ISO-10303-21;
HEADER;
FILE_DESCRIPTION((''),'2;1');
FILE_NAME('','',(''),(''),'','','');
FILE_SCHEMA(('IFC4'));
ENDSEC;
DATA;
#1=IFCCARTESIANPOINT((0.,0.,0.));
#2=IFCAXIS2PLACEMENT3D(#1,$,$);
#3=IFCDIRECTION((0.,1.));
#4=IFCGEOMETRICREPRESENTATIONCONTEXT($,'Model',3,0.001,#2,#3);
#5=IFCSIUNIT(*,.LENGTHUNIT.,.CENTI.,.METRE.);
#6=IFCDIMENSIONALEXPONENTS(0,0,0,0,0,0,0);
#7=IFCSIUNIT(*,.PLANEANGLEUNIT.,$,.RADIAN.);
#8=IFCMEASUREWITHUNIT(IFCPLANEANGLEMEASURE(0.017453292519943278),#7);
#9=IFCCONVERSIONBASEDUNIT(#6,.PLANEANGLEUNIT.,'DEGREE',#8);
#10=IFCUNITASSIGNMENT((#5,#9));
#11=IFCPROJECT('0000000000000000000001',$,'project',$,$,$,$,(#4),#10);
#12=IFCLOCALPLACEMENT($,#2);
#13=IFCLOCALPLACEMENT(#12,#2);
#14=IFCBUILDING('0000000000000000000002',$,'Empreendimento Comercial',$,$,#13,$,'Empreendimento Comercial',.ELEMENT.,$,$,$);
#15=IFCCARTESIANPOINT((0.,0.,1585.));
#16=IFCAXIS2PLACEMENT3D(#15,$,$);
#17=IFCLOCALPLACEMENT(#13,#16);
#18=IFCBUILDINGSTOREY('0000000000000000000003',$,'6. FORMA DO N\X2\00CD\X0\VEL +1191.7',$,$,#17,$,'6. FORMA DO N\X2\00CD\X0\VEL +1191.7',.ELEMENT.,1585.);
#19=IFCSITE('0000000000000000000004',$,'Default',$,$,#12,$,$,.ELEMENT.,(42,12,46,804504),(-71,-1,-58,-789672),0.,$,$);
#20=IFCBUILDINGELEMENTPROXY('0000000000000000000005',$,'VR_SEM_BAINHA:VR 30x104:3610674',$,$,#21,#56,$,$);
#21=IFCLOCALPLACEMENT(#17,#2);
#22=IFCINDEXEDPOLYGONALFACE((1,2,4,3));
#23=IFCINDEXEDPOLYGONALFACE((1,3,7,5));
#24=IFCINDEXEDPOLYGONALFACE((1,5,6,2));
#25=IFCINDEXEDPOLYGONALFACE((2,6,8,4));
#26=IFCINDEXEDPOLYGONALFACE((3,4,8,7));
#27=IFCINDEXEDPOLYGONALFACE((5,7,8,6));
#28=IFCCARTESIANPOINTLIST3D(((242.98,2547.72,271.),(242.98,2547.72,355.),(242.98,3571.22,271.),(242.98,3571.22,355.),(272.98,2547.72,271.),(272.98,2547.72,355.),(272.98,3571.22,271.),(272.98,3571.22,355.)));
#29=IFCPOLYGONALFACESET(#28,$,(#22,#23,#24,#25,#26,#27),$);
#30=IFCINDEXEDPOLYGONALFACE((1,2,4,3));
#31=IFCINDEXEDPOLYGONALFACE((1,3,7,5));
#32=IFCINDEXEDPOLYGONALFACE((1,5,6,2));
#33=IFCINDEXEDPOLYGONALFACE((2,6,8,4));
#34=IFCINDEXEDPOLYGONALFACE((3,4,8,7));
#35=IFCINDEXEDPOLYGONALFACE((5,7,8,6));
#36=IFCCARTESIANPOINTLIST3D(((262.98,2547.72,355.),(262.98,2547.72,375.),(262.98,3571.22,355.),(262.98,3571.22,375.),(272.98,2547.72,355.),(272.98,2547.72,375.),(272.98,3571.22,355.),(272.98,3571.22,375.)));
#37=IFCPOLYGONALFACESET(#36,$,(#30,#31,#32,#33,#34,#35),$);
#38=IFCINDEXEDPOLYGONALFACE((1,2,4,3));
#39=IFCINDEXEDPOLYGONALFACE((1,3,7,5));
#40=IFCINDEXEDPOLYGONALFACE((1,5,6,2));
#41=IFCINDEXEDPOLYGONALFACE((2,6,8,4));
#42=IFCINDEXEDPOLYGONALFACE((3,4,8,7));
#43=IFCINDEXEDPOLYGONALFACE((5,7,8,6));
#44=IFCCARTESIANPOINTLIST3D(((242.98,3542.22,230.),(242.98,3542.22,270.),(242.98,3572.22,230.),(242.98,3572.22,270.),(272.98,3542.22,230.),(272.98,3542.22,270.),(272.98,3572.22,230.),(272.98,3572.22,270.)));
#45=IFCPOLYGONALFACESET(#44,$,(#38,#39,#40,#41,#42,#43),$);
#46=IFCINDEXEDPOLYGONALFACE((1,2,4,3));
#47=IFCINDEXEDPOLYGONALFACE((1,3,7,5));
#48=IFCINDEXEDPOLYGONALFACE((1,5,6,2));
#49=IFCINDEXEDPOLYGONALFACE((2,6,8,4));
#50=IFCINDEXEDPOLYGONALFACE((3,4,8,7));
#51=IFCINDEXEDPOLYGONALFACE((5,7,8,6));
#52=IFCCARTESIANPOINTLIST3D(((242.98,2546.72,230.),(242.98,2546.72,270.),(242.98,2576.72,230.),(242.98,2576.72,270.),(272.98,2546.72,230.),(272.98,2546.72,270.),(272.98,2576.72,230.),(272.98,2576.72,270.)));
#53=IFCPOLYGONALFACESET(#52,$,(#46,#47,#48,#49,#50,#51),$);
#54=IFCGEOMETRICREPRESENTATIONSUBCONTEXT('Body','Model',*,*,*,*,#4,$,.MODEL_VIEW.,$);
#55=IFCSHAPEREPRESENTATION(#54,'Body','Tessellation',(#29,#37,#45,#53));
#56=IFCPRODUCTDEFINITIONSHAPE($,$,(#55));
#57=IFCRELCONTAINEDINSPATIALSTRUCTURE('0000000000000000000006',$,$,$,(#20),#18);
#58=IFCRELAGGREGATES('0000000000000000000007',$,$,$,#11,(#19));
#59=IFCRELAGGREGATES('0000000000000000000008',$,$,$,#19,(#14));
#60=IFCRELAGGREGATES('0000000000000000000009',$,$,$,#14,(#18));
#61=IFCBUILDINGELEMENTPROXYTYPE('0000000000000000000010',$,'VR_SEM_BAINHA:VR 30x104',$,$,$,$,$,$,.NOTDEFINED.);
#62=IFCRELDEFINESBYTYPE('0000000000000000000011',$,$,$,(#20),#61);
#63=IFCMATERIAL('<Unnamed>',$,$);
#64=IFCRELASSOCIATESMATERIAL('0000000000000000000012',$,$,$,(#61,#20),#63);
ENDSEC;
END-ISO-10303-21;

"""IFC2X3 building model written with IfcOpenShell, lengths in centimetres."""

from ifc_helpers import new_model, entity, si_unit, converted_unit, direction, frame, frame_2d, origin, place, context, subcontext, project, spatial, rectangle, extrude, source, transform, mapped, material, type_object, type_shapes, element, save


model = new_model("IFC2X3")

# Units and contexts
model_context = context("Model", 3, precision=0.001, world=origin(), true_north=direction((0.0, 1.0)))
body_context = subcontext(model_context, "Body", "Model", "MODEL_VIEW")
ifc_project = project(units=[si_unit("LENGTHUNIT", "METRE", prefix="CENTI"), converted_unit("PLANEANGLEUNIT", "DEGREE", entity("IfcPlaneAngleMeasure", 0.017453292519943278), si_unit("PLANEANGLEUNIT", "RADIAN"), dimensions=[0, 0, 0, 0, 0, 0, 0])], contexts=[model_context])

# Site, building, storey
site_placement = place(None, origin())
site = spatial("IfcSite", under=ifc_project, at=site_placement, Name="Default", CompositionType="ELEMENT", RefLatitude=(42, 12, 46, 804504), RefLongitude=(-71, -1, -58, -789672), RefElevation=0.0)
building_placement = place(site_placement, origin())
building = spatial("IfcBuilding", under=site, at=building_placement, Name="Empreendimento Comercial", LongName="Empreendimento Comercial", CompositionType="ELEMENT")
storey_placement = place(building_placement, frame((0.0, 0.0, 1585.0)))
storey = spatial("IfcBuildingStorey", under=building, at=storey_placement, Name="6. FORMA DO NÍVEL +1191.7", LongName="6. FORMA DO NÍVEL +1191.7", CompositionType="ELEMENT", Elevation=1585.0)

# Shared definitions
ifc_material = material(Name="<Unnamed>")

# Building element proxy
building_element_proxy_type_1 = type_object("IfcBuildingElementProxyType", Name="VR_SEM_BAINHA:VR 30x104", PredefinedType="NOTDEFINED", material=ifc_material)
shared_shape_1 = source(origin(), body_context, "Body", "SweptSolid", [
    extrude(rectangle(XDim=1023.5, YDim=30.0, at=frame_2d((0.0, 0.0), x_axis=(1.0, 0.0))), frame((257.98, 3059.47, 1856.0), z_axis=(0.0, 0.0, 1.0), x_axis=(0.0, 1.0, 0.0)), (0.0, 0.0, 1.0), 84.0),
    extrude(rectangle(XDim=1023.5, YDim=10.0, at=frame_2d((0.0, 0.0), x_axis=(1.0, 0.0))), frame((267.98, 3059.47, 1940.0), z_axis=(0.0, 0.0, 1.0), x_axis=(0.0, 1.0, 0.0)), (0.0, 0.0, 1.0), 20.0),
    extrude(rectangle(XDim=30.0, YDim=30.0, at=frame_2d((0.0, 0.0), x_axis=(1.0, 0.0))), frame((257.98, 3557.22, 1815.0)), (0.0, 0.0, 1.0), 40.0),
    extrude(rectangle(XDim=30.0, YDim=30.0, at=frame_2d((0.0, 0.0), x_axis=(1.0, 0.0))), frame((257.98, 2561.72, 1815.0)), (0.0, 0.0, 1.0), 40.0),
])
type_shapes(building_element_proxy_type_1, [shared_shape_1])
proxy_1_placement = place(storey_placement, frame((0.0, 0.0, -1585.0)))
element("IfcBuildingElementProxy", 1, at=proxy_1_placement, inside=storey, type_object=building_element_proxy_type_1, material=ifc_material, Name="VR_SEM_BAINHA:VR 30x104:3610674", context=body_context, shape_type="MappedRepresentation", body=[
    mapped(shared_shape_1, transform((0.0, 0.0, 0.0), scale=1.0)),
])

save(model, "model.ifc")
